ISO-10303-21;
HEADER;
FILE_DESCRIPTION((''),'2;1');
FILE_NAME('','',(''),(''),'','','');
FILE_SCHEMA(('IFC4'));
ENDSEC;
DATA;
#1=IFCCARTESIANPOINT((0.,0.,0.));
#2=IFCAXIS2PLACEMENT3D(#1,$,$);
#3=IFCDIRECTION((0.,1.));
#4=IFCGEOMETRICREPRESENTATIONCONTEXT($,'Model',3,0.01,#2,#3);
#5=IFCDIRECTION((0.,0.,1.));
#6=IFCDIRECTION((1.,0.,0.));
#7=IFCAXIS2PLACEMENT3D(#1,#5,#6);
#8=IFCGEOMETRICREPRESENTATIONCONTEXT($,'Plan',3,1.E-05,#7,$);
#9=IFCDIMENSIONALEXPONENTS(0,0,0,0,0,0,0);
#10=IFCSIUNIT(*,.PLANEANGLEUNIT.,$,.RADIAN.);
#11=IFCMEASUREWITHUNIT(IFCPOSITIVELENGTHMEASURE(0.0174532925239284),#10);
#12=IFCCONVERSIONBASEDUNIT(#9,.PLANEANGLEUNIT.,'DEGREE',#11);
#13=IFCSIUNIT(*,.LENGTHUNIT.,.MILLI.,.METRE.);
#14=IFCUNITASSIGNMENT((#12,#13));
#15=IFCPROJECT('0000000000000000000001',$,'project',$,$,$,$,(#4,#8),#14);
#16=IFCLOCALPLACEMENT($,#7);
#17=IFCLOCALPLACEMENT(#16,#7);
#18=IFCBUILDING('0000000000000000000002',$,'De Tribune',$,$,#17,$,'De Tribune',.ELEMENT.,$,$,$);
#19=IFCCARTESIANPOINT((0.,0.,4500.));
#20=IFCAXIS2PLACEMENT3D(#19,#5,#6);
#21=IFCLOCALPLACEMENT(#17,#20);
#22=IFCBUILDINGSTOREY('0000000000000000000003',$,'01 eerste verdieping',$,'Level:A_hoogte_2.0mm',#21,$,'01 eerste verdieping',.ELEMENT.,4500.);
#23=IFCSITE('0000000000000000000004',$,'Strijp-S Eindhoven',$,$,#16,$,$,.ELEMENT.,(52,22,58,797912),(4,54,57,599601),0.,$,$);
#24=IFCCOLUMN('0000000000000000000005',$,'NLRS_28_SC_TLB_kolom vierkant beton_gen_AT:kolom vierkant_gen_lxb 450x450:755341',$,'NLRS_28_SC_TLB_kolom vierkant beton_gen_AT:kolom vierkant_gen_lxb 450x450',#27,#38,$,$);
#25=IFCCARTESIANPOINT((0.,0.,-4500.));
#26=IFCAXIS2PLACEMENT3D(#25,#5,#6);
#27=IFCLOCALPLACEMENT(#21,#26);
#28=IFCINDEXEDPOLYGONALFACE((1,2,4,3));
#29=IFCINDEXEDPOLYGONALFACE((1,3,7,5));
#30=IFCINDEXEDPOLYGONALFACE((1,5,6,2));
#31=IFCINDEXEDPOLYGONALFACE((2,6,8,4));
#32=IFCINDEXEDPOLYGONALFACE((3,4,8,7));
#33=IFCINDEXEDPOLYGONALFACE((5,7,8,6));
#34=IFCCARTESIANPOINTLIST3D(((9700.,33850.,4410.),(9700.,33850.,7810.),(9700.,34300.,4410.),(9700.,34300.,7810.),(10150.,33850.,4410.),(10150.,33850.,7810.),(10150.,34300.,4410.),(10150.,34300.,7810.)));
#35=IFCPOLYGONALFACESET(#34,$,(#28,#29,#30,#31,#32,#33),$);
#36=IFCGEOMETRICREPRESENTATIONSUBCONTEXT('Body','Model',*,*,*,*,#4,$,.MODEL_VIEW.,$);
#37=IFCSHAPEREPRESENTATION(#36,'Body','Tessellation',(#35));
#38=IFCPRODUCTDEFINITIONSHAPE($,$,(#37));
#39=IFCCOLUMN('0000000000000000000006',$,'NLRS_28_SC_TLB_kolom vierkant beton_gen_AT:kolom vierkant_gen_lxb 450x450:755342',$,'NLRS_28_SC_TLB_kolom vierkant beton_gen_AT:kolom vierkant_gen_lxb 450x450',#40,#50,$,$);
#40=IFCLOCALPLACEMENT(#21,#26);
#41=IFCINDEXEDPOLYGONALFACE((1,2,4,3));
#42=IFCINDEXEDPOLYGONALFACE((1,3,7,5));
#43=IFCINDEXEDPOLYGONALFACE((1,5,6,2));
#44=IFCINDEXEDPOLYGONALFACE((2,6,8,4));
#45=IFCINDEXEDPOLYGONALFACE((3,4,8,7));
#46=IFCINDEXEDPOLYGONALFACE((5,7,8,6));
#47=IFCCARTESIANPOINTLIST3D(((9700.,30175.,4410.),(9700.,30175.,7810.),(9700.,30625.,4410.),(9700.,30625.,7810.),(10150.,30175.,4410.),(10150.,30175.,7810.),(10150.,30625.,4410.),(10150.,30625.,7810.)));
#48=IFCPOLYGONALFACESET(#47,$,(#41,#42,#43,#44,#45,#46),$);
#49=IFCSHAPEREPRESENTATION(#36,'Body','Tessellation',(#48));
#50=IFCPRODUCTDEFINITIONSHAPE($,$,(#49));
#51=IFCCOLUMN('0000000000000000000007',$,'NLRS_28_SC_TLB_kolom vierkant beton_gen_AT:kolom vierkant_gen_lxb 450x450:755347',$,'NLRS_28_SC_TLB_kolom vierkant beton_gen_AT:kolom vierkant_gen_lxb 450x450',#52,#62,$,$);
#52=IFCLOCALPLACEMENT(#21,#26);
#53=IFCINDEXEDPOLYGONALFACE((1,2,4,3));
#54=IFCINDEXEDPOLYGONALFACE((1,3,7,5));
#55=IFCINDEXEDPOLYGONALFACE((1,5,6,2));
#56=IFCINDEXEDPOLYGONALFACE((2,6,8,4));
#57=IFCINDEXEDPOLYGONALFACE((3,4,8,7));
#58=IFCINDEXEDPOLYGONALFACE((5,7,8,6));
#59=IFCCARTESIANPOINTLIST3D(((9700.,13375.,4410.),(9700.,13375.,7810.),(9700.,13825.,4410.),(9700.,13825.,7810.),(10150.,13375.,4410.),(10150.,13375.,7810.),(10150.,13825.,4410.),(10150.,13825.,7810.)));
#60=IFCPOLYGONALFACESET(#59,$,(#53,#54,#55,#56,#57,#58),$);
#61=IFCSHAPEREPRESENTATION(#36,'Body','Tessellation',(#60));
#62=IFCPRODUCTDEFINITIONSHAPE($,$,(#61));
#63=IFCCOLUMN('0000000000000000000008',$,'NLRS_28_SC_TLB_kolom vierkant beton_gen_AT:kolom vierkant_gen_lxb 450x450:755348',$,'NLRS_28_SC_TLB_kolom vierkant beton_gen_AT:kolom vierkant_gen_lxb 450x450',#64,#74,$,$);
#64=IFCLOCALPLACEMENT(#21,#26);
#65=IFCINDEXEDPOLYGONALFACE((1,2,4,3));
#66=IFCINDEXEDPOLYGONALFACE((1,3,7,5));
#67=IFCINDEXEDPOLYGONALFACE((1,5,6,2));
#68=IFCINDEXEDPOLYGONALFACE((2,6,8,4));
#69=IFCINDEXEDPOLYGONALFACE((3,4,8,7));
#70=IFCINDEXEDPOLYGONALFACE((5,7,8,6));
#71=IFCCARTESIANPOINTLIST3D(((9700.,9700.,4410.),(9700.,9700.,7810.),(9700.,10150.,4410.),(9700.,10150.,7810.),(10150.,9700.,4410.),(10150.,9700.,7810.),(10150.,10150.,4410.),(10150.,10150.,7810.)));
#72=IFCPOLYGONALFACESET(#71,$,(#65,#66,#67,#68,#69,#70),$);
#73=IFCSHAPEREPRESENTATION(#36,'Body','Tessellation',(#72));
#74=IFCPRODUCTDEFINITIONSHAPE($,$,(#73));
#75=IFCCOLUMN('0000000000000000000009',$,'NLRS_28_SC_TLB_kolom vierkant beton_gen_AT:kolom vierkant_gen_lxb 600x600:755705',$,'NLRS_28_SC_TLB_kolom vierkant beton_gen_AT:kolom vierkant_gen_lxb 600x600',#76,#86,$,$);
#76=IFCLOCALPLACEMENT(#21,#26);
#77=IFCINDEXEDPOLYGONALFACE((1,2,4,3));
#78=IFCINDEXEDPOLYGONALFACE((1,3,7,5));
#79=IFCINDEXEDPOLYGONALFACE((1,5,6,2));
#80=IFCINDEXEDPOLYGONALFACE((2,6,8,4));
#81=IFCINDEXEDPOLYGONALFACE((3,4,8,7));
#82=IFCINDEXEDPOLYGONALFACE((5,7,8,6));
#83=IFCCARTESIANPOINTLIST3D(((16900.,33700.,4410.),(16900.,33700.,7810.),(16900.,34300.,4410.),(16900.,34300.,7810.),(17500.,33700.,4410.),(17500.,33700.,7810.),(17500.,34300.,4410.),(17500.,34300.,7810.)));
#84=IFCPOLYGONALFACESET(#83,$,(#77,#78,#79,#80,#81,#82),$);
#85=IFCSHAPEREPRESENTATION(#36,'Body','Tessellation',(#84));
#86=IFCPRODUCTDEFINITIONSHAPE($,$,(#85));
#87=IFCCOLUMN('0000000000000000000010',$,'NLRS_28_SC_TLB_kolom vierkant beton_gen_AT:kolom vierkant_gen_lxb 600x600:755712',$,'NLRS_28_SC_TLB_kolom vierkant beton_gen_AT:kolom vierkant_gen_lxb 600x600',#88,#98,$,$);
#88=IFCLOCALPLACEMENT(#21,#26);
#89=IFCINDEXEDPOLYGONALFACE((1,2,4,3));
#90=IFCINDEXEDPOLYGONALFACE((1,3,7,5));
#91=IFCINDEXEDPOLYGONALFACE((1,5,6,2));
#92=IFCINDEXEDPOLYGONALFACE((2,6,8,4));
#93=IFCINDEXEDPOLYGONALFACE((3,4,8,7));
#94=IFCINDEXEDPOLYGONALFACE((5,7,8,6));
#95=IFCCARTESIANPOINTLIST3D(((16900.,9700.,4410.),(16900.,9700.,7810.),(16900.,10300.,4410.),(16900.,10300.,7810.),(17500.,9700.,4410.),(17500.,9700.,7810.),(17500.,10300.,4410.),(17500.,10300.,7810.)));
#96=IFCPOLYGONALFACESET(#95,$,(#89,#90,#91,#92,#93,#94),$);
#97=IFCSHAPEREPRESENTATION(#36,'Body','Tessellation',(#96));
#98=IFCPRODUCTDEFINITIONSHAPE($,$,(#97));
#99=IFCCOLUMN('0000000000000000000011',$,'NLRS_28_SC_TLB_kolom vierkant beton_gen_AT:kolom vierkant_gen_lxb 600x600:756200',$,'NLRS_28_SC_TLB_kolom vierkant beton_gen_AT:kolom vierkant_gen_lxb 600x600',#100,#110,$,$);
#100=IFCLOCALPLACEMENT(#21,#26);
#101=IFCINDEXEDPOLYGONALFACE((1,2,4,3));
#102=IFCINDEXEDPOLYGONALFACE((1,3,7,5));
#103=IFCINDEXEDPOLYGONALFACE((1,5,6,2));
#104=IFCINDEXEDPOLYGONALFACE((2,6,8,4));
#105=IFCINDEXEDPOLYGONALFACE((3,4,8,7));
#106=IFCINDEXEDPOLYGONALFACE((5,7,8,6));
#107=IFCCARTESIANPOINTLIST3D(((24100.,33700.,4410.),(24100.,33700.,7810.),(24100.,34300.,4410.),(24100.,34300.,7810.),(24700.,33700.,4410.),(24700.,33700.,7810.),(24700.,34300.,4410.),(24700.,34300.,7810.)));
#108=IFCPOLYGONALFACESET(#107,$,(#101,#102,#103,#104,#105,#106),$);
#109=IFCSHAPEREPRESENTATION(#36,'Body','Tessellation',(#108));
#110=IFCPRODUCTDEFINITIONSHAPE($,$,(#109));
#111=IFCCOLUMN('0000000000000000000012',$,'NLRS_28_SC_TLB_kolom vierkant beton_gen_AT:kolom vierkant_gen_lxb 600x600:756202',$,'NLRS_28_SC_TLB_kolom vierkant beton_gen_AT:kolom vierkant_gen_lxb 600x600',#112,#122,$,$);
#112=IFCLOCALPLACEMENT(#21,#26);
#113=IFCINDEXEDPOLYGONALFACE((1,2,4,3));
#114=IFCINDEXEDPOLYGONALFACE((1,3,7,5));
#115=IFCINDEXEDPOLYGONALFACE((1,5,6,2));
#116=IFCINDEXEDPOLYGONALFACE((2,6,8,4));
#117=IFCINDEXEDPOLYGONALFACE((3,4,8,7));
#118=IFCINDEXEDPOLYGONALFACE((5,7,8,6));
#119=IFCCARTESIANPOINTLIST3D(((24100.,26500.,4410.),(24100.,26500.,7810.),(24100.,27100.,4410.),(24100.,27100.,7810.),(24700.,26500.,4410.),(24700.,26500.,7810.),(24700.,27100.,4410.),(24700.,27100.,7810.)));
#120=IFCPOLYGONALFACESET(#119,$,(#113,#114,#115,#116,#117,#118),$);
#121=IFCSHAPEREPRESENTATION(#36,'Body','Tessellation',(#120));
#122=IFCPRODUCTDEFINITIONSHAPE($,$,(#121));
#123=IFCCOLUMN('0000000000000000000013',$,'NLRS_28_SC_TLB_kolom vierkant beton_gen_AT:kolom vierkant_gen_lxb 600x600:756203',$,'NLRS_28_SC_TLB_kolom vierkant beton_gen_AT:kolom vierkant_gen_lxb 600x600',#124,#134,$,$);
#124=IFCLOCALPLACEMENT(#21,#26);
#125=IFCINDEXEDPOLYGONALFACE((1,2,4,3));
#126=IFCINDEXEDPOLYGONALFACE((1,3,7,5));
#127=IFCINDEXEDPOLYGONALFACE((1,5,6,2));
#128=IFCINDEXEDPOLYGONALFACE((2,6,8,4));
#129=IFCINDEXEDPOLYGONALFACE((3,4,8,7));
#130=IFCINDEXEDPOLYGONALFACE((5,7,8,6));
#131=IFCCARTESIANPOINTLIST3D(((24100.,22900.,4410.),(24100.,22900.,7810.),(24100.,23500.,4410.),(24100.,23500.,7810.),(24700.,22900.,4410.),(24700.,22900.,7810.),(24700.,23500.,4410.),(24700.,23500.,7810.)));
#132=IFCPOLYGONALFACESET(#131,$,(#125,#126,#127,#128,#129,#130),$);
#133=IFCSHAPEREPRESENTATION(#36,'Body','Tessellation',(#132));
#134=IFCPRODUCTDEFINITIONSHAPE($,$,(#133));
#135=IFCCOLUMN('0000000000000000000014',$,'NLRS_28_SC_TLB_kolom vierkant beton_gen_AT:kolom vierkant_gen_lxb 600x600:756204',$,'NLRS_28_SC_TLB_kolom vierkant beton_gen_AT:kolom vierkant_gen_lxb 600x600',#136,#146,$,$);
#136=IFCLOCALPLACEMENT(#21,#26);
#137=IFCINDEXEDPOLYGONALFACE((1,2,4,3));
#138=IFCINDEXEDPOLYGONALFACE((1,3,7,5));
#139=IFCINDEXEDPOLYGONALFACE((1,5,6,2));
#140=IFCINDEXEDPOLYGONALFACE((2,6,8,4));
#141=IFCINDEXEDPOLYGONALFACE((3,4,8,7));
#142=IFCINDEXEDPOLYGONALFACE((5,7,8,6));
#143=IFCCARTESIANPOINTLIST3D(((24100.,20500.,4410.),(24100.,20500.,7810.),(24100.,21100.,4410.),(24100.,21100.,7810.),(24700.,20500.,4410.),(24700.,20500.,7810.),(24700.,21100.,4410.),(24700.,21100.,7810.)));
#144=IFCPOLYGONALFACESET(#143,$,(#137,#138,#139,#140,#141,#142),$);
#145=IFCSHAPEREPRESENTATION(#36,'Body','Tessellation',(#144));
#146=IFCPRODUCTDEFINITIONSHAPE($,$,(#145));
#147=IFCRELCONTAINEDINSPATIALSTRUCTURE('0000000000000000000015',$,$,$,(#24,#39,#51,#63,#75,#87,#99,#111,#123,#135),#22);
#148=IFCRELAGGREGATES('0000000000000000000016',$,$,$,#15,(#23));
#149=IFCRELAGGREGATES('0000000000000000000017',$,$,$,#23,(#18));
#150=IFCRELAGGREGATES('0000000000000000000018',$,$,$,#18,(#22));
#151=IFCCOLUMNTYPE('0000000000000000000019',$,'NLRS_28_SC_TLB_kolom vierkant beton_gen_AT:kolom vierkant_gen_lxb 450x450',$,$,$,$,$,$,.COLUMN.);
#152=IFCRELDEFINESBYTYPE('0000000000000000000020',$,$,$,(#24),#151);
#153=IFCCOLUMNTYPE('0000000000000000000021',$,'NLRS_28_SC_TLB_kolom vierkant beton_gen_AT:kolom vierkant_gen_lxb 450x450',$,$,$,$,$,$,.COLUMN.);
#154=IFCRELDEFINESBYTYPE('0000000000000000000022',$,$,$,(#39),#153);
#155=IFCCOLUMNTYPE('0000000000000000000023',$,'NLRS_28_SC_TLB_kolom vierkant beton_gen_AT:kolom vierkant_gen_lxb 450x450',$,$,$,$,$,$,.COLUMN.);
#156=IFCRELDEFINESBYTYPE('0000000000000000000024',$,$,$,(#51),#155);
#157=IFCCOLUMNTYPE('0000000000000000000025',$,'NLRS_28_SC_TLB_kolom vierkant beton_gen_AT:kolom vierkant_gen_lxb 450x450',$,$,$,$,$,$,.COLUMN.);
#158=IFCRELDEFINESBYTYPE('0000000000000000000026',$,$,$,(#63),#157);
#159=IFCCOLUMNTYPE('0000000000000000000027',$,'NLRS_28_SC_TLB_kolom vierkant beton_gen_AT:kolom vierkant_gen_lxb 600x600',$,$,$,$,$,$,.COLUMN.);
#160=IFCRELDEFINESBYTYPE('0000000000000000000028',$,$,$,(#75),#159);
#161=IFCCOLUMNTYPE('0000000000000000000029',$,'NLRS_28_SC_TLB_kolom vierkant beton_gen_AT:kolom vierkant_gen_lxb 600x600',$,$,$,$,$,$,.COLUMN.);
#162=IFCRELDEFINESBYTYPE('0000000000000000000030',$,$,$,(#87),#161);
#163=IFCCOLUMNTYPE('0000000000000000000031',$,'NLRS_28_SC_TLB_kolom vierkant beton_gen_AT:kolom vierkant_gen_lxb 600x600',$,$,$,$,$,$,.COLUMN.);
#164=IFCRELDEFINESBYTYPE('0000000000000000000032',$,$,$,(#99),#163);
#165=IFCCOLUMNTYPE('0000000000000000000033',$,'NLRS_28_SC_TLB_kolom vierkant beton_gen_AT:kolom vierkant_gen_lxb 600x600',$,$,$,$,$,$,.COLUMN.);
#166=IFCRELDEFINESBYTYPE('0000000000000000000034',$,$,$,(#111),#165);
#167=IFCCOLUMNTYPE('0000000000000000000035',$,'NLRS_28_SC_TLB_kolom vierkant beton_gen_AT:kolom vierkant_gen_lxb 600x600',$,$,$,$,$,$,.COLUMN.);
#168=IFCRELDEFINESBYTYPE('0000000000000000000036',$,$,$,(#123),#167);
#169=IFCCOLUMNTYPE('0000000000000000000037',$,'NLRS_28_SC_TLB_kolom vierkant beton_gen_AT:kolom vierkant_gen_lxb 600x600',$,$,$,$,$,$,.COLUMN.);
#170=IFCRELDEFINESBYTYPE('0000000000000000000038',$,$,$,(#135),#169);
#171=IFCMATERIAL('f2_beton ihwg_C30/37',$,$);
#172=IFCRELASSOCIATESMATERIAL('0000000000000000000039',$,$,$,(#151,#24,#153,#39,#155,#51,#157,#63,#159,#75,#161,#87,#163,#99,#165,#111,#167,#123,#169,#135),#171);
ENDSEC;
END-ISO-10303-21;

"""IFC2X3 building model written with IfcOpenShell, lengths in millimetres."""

from ifc_helpers import new_model, entity, si_unit, converted_unit, direction, frame, frame_2d, origin, origin_with_axes, place, context, subcontext, project, spatial, rectangle, extrude, source, transform, mapped, material, type_object, element, save


model = new_model("IFC2X3")

# Units and contexts
model_context = context("Model", 3, precision=0.01, world=origin(), true_north=direction((0.0, 1.0)))
plan_context = context("Plan", 3, precision=1e-05, world=origin_with_axes())
body_context = subcontext(model_context, "Body", "Model", "MODEL_VIEW")
ifc_project = project(units=[converted_unit("PLANEANGLEUNIT", "DEGREE", entity("IfcPositiveLengthMeasure", 0.0174532925239284), si_unit("PLANEANGLEUNIT", "RADIAN"), dimensions=[0, 0, 0, 0, 0, 0, 0]), si_unit("LENGTHUNIT", "METRE", prefix="MILLI")], contexts=[model_context, plan_context])

# Site, building, storey
site_placement = place(None, origin_with_axes())
site = spatial("IfcSite", under=ifc_project, at=site_placement, Name="Strijp-S Eindhoven", CompositionType="ELEMENT", RefLatitude=(52, 22, 58, 797912), RefLongitude=(4, 54, 57, 599601), RefElevation=0.0)
building_placement = place(site_placement, origin_with_axes())
building = spatial("IfcBuilding", under=site, at=building_placement, Name="De Tribune", LongName="De Tribune", CompositionType="ELEMENT")
storey_placement = place(building_placement, frame((0.0, 0.0, 4500.0), z_axis=(0.0, 0.0, 1.0), x_axis=(1.0, 0.0, 0.0)))
storey = spatial("IfcBuildingStorey", under=building, at=storey_placement, Name="01 eerste verdieping", ObjectType="Level:A_hoogte_2.0mm", LongName="01 eerste verdieping", CompositionType="ELEMENT", Elevation=4500.0)

# Columns
ifc_material = material(Name="f2_beton ihwg_C30/37")
column_type_1 = type_object("IfcColumnType", Name="NLRS_28_SC_TLB_kolom vierkant beton_gen_AT:kolom vierkant_gen_lxb 450x450", PredefinedType="COLUMN", material=ifc_material)
shared_shape_1 = source(origin(), body_context, "Body", "SweptSolid", [
    extrude(rectangle(XDim=450.0, YDim=450.0, at=frame_2d((0.0, 0.0), x_axis=(1.0, 0.0))), frame((9925.0, 34075.0, 4410.0), z_axis=(0.0, 0.0, 1.0), x_axis=(-1.0, 0.0, 0.0)), (0.0, 0.0, 1.0), 3400.0),
])
column_1_placement = place(storey_placement, frame((0.0, 0.0, -4500.0), z_axis=(0.0, 0.0, 1.0), x_axis=(1.0, 0.0, 0.0)))
element("IfcColumn", 1, at=column_1_placement, inside=storey, type_object=column_type_1, material=ifc_material, Name="NLRS_28_SC_TLB_kolom vierkant beton_gen_AT:kolom vierkant_gen_lxb 450x450:755341", ObjectType="NLRS_28_SC_TLB_kolom vierkant beton_gen_AT:kolom vierkant_gen_lxb 450x450", context=body_context, shape_type="MappedRepresentation", body=[
    mapped(shared_shape_1, transform((0.0, 0.0, 0.0), scale=1.0)),
])
column_type_2 = type_object("IfcColumnType", Name="NLRS_28_SC_TLB_kolom vierkant beton_gen_AT:kolom vierkant_gen_lxb 450x450", PredefinedType="COLUMN", material=ifc_material)
shared_shape_2 = source(origin(), body_context, "Body", "SweptSolid", [
    extrude(rectangle(XDim=450.0, YDim=450.0, at=frame_2d((0.0, 0.0), x_axis=(1.0, 0.0))), frame((9925.0, 30400.0, 4410.0), z_axis=(0.0, 0.0, 1.0), x_axis=(-1.0, 0.0, 0.0)), (0.0, 0.0, 1.0), 3400.0),
])
column_2_placement = place(storey_placement, frame((0.0, 0.0, -4500.0), z_axis=(0.0, 0.0, 1.0), x_axis=(1.0, 0.0, 0.0)))
element("IfcColumn", 2, at=column_2_placement, inside=storey, type_object=column_type_2, material=ifc_material, Name="NLRS_28_SC_TLB_kolom vierkant beton_gen_AT:kolom vierkant_gen_lxb 450x450:755342", ObjectType="NLRS_28_SC_TLB_kolom vierkant beton_gen_AT:kolom vierkant_gen_lxb 450x450", context=body_context, shape_type="MappedRepresentation", body=[
    mapped(shared_shape_2, transform((0.0, 0.0, 0.0), scale=1.0)),
])
column_type_3 = type_object("IfcColumnType", Name="NLRS_28_SC_TLB_kolom vierkant beton_gen_AT:kolom vierkant_gen_lxb 450x450", PredefinedType="COLUMN", material=ifc_material)
shared_shape_3 = source(origin(), body_context, "Body", "SweptSolid", [
    extrude(rectangle(XDim=450.0, YDim=450.0, at=frame_2d((0.0, 0.0), x_axis=(1.0, 0.0))), frame((9925.0, 13600.0, 4410.0), z_axis=(0.0, 0.0, 1.0), x_axis=(-1.0, 0.0, 0.0)), (0.0, 0.0, 1.0), 3400.0),
])
column_3_placement = place(storey_placement, frame((0.0, 0.0, -4500.0), z_axis=(0.0, 0.0, 1.0), x_axis=(1.0, 0.0, 0.0)))
element("IfcColumn", 3, at=column_3_placement, inside=storey, type_object=column_type_3, material=ifc_material, Name="NLRS_28_SC_TLB_kolom vierkant beton_gen_AT:kolom vierkant_gen_lxb 450x450:755347", ObjectType="NLRS_28_SC_TLB_kolom vierkant beton_gen_AT:kolom vierkant_gen_lxb 450x450", context=body_context, shape_type="MappedRepresentation", body=[
    mapped(shared_shape_3, transform((0.0, 0.0, 0.0), scale=1.0)),
])
column_type_4 = type_object("IfcColumnType", Name="NLRS_28_SC_TLB_kolom vierkant beton_gen_AT:kolom vierkant_gen_lxb 450x450", PredefinedType="COLUMN", material=ifc_material)
shared_shape_4 = source(origin(), body_context, "Body", "SweptSolid", [
    extrude(rectangle(XDim=450.0, YDim=450.0, at=frame_2d((0.0, 0.0), x_axis=(1.0, 0.0))), frame((9925.0, 9925.0, 4410.0), z_axis=(0.0, 0.0, 1.0), x_axis=(-1.0, 0.0, 0.0)), (0.0, 0.0, 1.0), 3400.0),
])
column_4_placement = place(storey_placement, frame((0.0, 0.0, -4500.0), z_axis=(0.0, 0.0, 1.0), x_axis=(1.0, 0.0, 0.0)))
element("IfcColumn", 4, at=column_4_placement, inside=storey, type_object=column_type_4, material=ifc_material, Name="NLRS_28_SC_TLB_kolom vierkant beton_gen_AT:kolom vierkant_gen_lxb 450x450:755348", ObjectType="NLRS_28_SC_TLB_kolom vierkant beton_gen_AT:kolom vierkant_gen_lxb 450x450", context=body_context, shape_type="MappedRepresentation", body=[
    mapped(shared_shape_4, transform((0.0, 0.0, 0.0), scale=1.0)),
])
column_type_5 = type_object("IfcColumnType", Name="NLRS_28_SC_TLB_kolom vierkant beton_gen_AT:kolom vierkant_gen_lxb 600x600", PredefinedType="COLUMN", material=ifc_material)
shared_shape_5 = source(origin(), body_context, "Body", "SweptSolid", [
    extrude(rectangle(XDim=600.0, YDim=600.0, at=frame_2d((0.0, 0.0), x_axis=(1.0, 0.0))), frame((17200.0, 34000.0, 4410.0), z_axis=(0.0, 0.0, 1.0), x_axis=(0.0, -1.0, 0.0)), (0.0, 0.0, 1.0), 3400.0),
])
column_5_placement = place(storey_placement, frame((0.0, 0.0, -4500.0), z_axis=(0.0, 0.0, 1.0), x_axis=(1.0, 0.0, 0.0)))
element("IfcColumn", 5, at=column_5_placement, inside=storey, type_object=column_type_5, material=ifc_material, Name="NLRS_28_SC_TLB_kolom vierkant beton_gen_AT:kolom vierkant_gen_lxb 600x600:755705", ObjectType="NLRS_28_SC_TLB_kolom vierkant beton_gen_AT:kolom vierkant_gen_lxb 600x600", context=body_context, shape_type="MappedRepresentation", body=[
    mapped(shared_shape_5, transform((0.0, 0.0, 0.0), scale=1.0)),
])
column_type_6 = type_object("IfcColumnType", Name="NLRS_28_SC_TLB_kolom vierkant beton_gen_AT:kolom vierkant_gen_lxb 600x600", PredefinedType="COLUMN", material=ifc_material)
shared_shape_6 = source(origin(), body_context, "Body", "SweptSolid", [
    extrude(rectangle(XDim=600.0, YDim=600.0, at=frame_2d((0.0, 0.0), x_axis=(1.0, 0.0))), frame((17200.0, 10000.0, 4410.0), z_axis=(0.0, 0.0, 1.0), x_axis=(0.0, -1.0, 0.0)), (0.0, 0.0, 1.0), 3400.0),
])
column_6_placement = place(storey_placement, frame((0.0, 0.0, -4500.0), z_axis=(0.0, 0.0, 1.0), x_axis=(1.0, 0.0, 0.0)))
element("IfcColumn", 6, at=column_6_placement, inside=storey, type_object=column_type_6, material=ifc_material, Name="NLRS_28_SC_TLB_kolom vierkant beton_gen_AT:kolom vierkant_gen_lxb 600x600:755712", ObjectType="NLRS_28_SC_TLB_kolom vierkant beton_gen_AT:kolom vierkant_gen_lxb 600x600", context=body_context, shape_type="MappedRepresentation", body=[
    mapped(shared_shape_6, transform((0.0, 0.0, 0.0), scale=1.0)),
])
column_type_7 = type_object("IfcColumnType", Name="NLRS_28_SC_TLB_kolom vierkant beton_gen_AT:kolom vierkant_gen_lxb 600x600", PredefinedType="COLUMN", material=ifc_material)
shared_shape_7 = source(origin(), body_context, "Body", "SweptSolid", [
    extrude(rectangle(XDim=600.0, YDim=600.0, at=frame_2d((0.0, 0.0), x_axis=(1.0, 0.0))), frame((24400.0, 34000.0, 4410.0), z_axis=(0.0, 0.0, 1.0), x_axis=(0.0, -1.0, 0.0)), (0.0, 0.0, 1.0), 3400.0),
])
column_7_placement = place(storey_placement, frame((0.0, 0.0, -4500.0), z_axis=(0.0, 0.0, 1.0), x_axis=(1.0, 0.0, 0.0)))
element("IfcColumn", 7, at=column_7_placement, inside=storey, type_object=column_type_7, material=ifc_material, Name="NLRS_28_SC_TLB_kolom vierkant beton_gen_AT:kolom vierkant_gen_lxb 600x600:756200", ObjectType="NLRS_28_SC_TLB_kolom vierkant beton_gen_AT:kolom vierkant_gen_lxb 600x600", context=body_context, shape_type="MappedRepresentation", body=[
    mapped(shared_shape_7, transform((0.0, 0.0, 0.0), scale=1.0)),
])
column_type_8 = type_object("IfcColumnType", Name="NLRS_28_SC_TLB_kolom vierkant beton_gen_AT:kolom vierkant_gen_lxb 600x600", PredefinedType="COLUMN", material=ifc_material)
shared_shape_8 = source(origin(), body_context, "Body", "SweptSolid", [
    extrude(rectangle(XDim=600.0, YDim=600.0, at=frame_2d((0.0, 0.0), x_axis=(1.0, 0.0))), frame((24400.0, 26800.0, 4410.0), z_axis=(0.0, 0.0, 1.0), x_axis=(-1.0, 0.0, 0.0)), (0.0, 0.0, 1.0), 3400.0),
])
column_8_placement = place(storey_placement, frame((0.0, 0.0, -4500.0), z_axis=(0.0, 0.0, 1.0), x_axis=(1.0, 0.0, 0.0)))
element("IfcColumn", 8, at=column_8_placement, inside=storey, type_object=column_type_8, material=ifc_material, Name="NLRS_28_SC_TLB_kolom vierkant beton_gen_AT:kolom vierkant_gen_lxb 600x600:756202", ObjectType="NLRS_28_SC_TLB_kolom vierkant beton_gen_AT:kolom vierkant_gen_lxb 600x600", context=body_context, shape_type="MappedRepresentation", body=[
    mapped(shared_shape_8, transform((0.0, 0.0, 0.0), scale=1.0)),
])
column_type_9 = type_object("IfcColumnType", Name="NLRS_28_SC_TLB_kolom vierkant beton_gen_AT:kolom vierkant_gen_lxb 600x600", PredefinedType="COLUMN", material=ifc_material)
shared_shape_9 = source(origin(), body_context, "Body", "SweptSolid", [
    extrude(rectangle(XDim=600.0, YDim=600.0, at=frame_2d((0.0, 0.0), x_axis=(1.0, 0.0))), frame((24400.0, 23200.0, 4410.0), z_axis=(0.0, 0.0, 1.0), x_axis=(-1.0, 0.0, 0.0)), (0.0, 0.0, 1.0), 3400.0),
])
column_9_placement = place(storey_placement, frame((0.0, 0.0, -4500.0), z_axis=(0.0, 0.0, 1.0), x_axis=(1.0, 0.0, 0.0)))
element("IfcColumn", 9, at=column_9_placement, inside=storey, type_object=column_type_9, material=ifc_material, Name="NLRS_28_SC_TLB_kolom vierkant beton_gen_AT:kolom vierkant_gen_lxb 600x600:756203", ObjectType="NLRS_28_SC_TLB_kolom vierkant beton_gen_AT:kolom vierkant_gen_lxb 600x600", context=body_context, shape_type="MappedRepresentation", body=[
    mapped(shared_shape_9, transform((0.0, 0.0, 0.0), scale=1.0)),
])
column_type_10 = type_object("IfcColumnType", Name="NLRS_28_SC_TLB_kolom vierkant beton_gen_AT:kolom vierkant_gen_lxb 600x600", PredefinedType="COLUMN", material=ifc_material)
shared_shape_10 = source(origin(), body_context, "Body", "SweptSolid", [
    extrude(rectangle(XDim=600.0, YDim=600.0, at=frame_2d((0.0, 0.0), x_axis=(1.0, 0.0))), frame((24400.0, 20800.0, 4410.0), z_axis=(0.0, 0.0, 1.0), x_axis=(-1.0, 0.0, 0.0)), (0.0, 0.0, 1.0), 3400.0),
])
column_10_placement = place(storey_placement, frame((0.0, 0.0, -4500.0), z_axis=(0.0, 0.0, 1.0), x_axis=(1.0, 0.0, 0.0)))
element("IfcColumn", 10, at=column_10_placement, inside=storey, type_object=column_type_10, material=ifc_material, Name="NLRS_28_SC_TLB_kolom vierkant beton_gen_AT:kolom vierkant_gen_lxb 600x600:756204", ObjectType="NLRS_28_SC_TLB_kolom vierkant beton_gen_AT:kolom vierkant_gen_lxb 600x600", context=body_context, shape_type="MappedRepresentation", body=[
    mapped(shared_shape_10, transform((0.0, 0.0, 0.0), scale=1.0)),
])

save(model, "model.ifc")
